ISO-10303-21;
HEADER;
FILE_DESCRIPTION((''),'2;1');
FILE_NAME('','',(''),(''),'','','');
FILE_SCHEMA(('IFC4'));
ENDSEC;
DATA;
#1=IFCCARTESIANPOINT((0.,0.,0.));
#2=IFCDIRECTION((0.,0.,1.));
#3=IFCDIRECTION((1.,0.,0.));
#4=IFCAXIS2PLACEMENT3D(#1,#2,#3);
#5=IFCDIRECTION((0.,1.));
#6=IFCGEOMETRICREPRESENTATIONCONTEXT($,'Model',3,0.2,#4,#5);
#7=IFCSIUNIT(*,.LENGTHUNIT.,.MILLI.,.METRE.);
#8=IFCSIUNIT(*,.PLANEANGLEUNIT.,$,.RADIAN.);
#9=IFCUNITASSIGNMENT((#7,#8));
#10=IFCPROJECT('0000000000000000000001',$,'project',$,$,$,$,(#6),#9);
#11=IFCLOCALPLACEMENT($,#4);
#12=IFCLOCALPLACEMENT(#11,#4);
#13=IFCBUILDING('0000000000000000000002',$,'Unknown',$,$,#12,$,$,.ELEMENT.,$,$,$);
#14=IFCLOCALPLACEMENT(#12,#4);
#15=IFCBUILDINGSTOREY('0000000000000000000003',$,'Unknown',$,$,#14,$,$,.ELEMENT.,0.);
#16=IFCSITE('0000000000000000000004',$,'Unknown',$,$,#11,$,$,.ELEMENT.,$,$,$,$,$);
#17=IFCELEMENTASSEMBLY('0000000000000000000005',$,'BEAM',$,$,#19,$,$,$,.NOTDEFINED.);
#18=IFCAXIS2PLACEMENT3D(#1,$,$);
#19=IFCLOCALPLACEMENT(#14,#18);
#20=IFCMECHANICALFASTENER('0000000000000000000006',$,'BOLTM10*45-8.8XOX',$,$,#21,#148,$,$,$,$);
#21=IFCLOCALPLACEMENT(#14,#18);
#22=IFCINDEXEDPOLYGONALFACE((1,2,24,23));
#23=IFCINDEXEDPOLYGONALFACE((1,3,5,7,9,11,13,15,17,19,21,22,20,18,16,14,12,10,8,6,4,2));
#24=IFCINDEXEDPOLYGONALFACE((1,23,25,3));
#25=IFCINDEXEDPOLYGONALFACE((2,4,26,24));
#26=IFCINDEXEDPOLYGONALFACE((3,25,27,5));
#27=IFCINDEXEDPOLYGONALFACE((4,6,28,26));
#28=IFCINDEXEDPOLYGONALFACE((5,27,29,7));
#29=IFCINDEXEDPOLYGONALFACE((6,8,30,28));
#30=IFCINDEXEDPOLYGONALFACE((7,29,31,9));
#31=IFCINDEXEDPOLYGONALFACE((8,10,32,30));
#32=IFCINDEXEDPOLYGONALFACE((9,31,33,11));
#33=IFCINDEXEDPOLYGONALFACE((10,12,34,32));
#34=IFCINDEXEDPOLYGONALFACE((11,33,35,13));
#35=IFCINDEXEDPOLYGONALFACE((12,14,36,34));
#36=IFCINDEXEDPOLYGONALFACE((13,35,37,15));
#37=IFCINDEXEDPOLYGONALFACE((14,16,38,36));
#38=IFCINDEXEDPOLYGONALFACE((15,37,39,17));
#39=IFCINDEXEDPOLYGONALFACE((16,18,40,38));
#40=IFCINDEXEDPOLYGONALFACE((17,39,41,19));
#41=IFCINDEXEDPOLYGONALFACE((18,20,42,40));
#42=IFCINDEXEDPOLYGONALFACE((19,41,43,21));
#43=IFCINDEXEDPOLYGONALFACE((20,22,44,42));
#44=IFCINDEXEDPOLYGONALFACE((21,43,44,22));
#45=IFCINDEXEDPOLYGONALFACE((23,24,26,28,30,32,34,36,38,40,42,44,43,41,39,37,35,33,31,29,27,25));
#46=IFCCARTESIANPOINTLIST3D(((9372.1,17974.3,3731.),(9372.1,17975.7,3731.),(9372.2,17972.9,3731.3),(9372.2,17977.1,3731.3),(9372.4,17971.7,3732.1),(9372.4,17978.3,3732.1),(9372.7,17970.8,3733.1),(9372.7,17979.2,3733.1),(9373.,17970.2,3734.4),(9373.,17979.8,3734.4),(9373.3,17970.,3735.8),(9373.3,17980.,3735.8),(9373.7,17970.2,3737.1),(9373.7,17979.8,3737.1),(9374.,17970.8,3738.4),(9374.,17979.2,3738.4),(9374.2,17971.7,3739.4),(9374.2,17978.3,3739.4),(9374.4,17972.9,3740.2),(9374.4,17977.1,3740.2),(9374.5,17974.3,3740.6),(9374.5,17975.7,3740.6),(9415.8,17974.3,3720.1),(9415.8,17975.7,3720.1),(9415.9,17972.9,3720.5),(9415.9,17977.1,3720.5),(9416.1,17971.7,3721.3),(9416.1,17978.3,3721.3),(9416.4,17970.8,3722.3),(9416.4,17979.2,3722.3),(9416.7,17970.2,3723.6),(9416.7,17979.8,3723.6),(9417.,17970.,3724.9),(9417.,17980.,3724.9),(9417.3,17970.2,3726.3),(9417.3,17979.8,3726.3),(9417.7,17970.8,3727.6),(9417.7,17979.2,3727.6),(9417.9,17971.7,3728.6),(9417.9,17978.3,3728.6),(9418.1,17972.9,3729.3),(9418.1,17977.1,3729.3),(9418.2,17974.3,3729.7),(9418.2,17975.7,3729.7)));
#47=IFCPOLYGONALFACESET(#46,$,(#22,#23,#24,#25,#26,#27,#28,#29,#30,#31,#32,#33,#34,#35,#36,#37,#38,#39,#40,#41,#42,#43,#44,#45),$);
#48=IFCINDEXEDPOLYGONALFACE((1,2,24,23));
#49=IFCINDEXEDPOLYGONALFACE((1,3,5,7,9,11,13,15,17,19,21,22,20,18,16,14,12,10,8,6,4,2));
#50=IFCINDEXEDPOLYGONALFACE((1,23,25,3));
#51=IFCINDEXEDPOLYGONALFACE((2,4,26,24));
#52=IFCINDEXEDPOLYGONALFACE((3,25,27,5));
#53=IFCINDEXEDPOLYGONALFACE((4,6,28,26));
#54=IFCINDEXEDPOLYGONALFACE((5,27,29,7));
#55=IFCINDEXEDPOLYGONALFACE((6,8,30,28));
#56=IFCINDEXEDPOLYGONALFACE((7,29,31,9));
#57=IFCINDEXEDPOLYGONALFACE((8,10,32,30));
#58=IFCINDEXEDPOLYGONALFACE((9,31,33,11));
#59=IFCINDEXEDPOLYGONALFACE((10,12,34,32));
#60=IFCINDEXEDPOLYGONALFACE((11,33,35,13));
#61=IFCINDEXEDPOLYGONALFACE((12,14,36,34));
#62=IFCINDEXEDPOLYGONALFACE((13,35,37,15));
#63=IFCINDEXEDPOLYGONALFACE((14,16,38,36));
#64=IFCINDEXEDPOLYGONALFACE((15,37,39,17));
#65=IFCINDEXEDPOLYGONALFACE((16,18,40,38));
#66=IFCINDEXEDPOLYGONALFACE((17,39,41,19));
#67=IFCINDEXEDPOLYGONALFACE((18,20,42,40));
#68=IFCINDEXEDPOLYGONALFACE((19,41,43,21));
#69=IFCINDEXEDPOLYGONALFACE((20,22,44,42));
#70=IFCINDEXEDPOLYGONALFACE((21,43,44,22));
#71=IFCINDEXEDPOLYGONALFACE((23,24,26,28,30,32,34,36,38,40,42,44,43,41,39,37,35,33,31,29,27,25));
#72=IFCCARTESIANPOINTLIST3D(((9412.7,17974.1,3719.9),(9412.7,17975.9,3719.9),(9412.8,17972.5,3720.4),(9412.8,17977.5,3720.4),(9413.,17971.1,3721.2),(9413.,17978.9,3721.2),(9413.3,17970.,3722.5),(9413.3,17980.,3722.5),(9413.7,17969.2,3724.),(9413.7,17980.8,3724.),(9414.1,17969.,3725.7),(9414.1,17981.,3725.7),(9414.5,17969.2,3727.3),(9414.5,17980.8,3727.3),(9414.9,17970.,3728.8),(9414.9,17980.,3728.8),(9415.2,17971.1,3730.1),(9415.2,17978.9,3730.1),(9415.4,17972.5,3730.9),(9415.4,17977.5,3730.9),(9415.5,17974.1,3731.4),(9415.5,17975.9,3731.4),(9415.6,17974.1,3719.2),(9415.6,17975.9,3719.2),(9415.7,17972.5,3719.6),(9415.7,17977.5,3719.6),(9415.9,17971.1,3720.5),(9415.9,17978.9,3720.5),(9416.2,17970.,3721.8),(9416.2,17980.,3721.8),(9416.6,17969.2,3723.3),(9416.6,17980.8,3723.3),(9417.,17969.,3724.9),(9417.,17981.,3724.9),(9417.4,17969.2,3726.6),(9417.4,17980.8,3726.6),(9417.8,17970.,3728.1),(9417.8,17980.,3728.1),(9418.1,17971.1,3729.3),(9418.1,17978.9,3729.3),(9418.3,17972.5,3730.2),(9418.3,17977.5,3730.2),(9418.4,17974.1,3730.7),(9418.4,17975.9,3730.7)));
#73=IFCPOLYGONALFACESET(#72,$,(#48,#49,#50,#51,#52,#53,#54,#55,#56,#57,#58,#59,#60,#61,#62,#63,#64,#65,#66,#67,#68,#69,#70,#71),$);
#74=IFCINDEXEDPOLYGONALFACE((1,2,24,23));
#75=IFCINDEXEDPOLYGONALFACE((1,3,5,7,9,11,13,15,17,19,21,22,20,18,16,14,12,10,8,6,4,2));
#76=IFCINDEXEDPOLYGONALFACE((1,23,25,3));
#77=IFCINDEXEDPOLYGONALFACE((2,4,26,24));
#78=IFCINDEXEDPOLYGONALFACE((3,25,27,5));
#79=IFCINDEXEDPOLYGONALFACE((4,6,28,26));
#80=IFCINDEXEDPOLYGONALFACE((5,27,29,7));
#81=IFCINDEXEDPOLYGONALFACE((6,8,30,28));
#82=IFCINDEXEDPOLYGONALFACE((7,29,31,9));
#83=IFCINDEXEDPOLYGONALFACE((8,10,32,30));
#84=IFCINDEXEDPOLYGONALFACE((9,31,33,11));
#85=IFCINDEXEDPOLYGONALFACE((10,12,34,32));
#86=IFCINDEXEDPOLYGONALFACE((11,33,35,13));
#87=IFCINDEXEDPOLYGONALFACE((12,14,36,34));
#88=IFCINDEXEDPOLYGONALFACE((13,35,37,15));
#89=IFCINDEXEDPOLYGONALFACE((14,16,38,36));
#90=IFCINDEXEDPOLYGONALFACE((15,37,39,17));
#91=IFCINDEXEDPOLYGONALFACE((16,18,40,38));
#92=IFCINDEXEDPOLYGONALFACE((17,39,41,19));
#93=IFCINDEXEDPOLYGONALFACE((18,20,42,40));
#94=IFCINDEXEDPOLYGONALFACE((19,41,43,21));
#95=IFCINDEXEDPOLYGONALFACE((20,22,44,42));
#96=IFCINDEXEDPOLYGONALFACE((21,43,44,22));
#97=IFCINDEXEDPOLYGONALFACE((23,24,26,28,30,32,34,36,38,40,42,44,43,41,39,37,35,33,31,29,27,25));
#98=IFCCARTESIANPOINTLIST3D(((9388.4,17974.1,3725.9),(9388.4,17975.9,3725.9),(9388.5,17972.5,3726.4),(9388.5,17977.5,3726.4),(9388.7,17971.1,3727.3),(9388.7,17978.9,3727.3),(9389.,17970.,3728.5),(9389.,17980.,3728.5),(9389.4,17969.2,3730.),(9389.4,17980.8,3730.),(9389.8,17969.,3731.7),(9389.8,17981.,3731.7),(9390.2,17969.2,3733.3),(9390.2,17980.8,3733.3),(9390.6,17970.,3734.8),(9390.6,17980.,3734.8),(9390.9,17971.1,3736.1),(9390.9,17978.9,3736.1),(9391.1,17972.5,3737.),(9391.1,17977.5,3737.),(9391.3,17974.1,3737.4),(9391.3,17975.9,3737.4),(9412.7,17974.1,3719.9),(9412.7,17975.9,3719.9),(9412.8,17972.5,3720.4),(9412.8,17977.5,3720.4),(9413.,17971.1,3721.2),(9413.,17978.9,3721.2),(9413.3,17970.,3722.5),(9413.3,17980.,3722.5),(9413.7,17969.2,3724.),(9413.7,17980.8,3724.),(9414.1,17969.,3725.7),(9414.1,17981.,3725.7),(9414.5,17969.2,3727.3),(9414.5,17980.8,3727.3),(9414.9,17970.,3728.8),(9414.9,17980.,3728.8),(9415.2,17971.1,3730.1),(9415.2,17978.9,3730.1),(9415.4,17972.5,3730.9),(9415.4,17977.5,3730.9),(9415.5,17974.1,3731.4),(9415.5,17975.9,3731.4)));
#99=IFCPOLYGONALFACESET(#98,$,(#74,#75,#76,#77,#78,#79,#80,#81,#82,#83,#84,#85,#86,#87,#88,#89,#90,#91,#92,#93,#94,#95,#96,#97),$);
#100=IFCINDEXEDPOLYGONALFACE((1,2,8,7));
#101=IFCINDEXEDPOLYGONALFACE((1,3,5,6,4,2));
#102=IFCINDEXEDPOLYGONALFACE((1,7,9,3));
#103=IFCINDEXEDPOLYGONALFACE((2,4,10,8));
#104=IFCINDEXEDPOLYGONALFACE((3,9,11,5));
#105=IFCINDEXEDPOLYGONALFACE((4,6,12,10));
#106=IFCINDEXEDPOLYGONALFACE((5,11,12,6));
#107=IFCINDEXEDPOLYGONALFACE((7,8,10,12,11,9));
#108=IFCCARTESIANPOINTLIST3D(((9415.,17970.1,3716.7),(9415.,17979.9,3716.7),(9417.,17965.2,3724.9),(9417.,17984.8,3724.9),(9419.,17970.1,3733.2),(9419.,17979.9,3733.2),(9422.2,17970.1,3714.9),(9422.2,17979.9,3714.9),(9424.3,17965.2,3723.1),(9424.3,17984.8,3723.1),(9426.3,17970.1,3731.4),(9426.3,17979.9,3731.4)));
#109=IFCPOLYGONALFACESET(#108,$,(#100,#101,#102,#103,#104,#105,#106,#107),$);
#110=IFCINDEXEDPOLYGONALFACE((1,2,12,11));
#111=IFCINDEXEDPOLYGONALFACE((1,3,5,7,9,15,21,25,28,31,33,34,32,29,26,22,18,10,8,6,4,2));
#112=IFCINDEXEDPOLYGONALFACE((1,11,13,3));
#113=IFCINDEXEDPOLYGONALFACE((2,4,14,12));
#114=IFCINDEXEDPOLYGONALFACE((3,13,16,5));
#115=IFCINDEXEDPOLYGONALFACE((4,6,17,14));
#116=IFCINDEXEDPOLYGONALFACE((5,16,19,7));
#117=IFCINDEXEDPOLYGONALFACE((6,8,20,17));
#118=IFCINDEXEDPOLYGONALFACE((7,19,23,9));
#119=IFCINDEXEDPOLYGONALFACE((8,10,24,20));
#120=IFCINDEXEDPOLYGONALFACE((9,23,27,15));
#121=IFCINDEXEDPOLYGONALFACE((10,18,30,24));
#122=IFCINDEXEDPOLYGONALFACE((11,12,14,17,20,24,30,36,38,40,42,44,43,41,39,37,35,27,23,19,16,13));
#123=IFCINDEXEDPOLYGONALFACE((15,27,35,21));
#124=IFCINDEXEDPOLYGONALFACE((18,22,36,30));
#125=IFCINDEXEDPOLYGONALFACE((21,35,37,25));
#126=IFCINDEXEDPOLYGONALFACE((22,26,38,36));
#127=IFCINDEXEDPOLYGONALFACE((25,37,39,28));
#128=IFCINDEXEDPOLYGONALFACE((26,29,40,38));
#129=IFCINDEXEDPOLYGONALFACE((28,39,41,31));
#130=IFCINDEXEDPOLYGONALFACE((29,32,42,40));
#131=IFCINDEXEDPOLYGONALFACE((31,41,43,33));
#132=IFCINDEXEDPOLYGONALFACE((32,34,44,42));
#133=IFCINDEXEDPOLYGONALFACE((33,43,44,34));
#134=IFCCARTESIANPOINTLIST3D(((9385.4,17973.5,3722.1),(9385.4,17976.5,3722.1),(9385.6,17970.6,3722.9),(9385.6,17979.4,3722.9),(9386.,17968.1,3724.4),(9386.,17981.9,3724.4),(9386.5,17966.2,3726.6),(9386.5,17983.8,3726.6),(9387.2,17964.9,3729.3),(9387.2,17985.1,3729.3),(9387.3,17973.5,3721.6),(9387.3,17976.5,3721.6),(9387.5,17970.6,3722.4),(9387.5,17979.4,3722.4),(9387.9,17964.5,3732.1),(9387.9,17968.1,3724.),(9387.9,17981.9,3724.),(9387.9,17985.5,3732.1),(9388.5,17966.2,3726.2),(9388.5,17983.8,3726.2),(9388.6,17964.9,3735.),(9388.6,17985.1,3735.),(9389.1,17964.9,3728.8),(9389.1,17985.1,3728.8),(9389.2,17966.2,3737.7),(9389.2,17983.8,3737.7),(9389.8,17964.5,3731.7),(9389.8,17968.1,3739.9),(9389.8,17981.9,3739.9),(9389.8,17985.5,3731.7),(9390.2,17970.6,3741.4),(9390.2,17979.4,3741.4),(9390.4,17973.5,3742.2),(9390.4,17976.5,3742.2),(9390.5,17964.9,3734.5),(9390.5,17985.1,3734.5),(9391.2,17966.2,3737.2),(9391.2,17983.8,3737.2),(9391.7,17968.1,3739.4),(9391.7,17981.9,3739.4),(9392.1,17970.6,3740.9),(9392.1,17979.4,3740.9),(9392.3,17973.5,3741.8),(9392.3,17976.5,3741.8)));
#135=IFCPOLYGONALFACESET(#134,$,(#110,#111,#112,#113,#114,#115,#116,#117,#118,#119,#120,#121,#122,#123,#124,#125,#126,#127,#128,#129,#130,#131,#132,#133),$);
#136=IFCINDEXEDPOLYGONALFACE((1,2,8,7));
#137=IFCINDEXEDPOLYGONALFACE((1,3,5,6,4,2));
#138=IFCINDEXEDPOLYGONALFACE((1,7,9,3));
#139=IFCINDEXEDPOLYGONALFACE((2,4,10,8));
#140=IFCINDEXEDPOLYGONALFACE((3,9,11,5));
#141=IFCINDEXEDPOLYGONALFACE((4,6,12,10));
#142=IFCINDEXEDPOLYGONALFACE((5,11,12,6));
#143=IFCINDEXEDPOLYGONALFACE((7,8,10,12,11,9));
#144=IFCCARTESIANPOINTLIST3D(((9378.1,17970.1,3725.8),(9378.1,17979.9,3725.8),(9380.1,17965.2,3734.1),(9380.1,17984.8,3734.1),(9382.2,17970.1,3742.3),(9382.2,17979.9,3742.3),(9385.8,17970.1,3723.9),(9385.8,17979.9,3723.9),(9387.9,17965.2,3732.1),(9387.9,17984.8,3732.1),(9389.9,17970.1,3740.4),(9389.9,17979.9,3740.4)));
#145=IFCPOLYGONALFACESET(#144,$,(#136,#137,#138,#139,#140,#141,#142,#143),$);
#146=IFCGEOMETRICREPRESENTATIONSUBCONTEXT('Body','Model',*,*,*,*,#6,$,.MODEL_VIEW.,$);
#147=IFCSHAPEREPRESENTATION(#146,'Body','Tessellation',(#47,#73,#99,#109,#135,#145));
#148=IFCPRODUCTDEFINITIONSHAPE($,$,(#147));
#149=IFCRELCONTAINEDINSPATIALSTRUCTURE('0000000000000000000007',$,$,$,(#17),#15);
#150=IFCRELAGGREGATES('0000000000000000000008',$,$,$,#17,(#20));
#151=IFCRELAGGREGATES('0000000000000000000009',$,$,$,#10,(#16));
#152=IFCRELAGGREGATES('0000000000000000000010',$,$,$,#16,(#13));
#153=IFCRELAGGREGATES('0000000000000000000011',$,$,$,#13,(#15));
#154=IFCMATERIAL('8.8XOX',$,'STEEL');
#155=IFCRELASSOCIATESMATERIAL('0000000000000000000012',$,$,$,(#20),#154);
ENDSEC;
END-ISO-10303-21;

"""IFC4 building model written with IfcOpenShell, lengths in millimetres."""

from ifc_helpers import new_model, si_unit, direction, frame, origin_with_axes, place, context, subcontext, project, spatial, line, arc, indexed_curve, outline, extrude, source, transform, mapped, material, element, aggregate, save


model = new_model("IFC4")

# Units and contexts
model_context = context("Model", 3, precision=0.2, world=origin_with_axes(), true_north=direction((0.0, 1.0)))
body_context = subcontext(model_context, "Body", "Model", "MODEL_VIEW")
ifc_project = project(units=[si_unit("LENGTHUNIT", "METRE", prefix="MILLI"), si_unit("PLANEANGLEUNIT", "RADIAN")], contexts=[model_context])

# Site, building, storey
site_placement = place(None, origin_with_axes())
site = spatial("IfcSite", under=ifc_project, at=site_placement, Name="Unknown", CompositionType="ELEMENT")
building_placement = place(site_placement, origin_with_axes())
building = spatial("IfcBuilding", under=site, at=building_placement, Name="Unknown", CompositionType="ELEMENT")
storey_placement = place(building_placement, origin_with_axes())
storey = spatial("IfcBuildingStorey", under=building, at=storey_placement, Name="Unknown", CompositionType="ELEMENT", Elevation=0.0)

# Shared definitions
ifc_material_1 = material(Name="8.8XOX", Category="STEEL")

# Element assembly, mechanical fastener
shared_shape_1 = source(origin_with_axes(), body_context, "Body", "SweptSolid", [
    extrude(outline(indexed_curve([(5.0, 0.0), (0.0, 5.0), (-5.0, 0.0), (0.0, -5.0)], segments=[arc(1, 2, 3), arc(3, 4, 1)])), frame((0.0, 0.0, 3.8), z_axis=(0.0, 0.0, -1.0), x_axis=(0.0, 1.0, 0.0)), (0.0, 0.0, 1.0), 45.0),
    extrude(outline(indexed_curve([(6.0, 0.0), (0.0, 6.0), (-6.0, 0.0), (0.0, -6.0)], segments=[arc(1, 2, 3), arc(3, 4, 1)])), frame((0.0, 0.0, 3.8), z_axis=(0.0, 0.0, -1.0), x_axis=(0.0, 1.0, 0.0)), (0.0, 0.0, 1.0), 3.0),
    extrude(outline(indexed_curve([(6.0, 0.0), (0.0, 6.0), (-6.0, 0.0), (0.0, -6.0)], segments=[arc(1, 2, 3), arc(3, 4, 1)])), frame((0.0, 0.0, 0.8), z_axis=(0.0, 0.0, -1.0), x_axis=(0.0, 1.0, 0.0)), (0.0, 0.0, 1.0), 25.0),
    extrude(outline(indexed_curve([(9.8, 0.0), (4.9, 8.5), (-4.9, 8.5), (-9.8, 0.0), (-4.9, -8.5), (4.9, -8.5)], segments=[line(1, 2, 3, 4, 5, 6, 1)])), frame((0.0, 0.0, 11.2), z_axis=(0.0, 0.0, -1.0), x_axis=(0.0, 1.0, 0.0)), (0.0, 0.0, 1.0), 7.5),
    extrude(outline(indexed_curve([(10.5, 0.0), (0.0, 10.5), (-10.5, 0.0), (0.0, -10.5)], segments=[arc(1, 2, 3), arc(3, 4, 1)])), frame((0.0, 0.0, -24.2), z_axis=(0.0, 0.0, -1.0), x_axis=(0.0, 1.0, 0.0)), (0.0, 0.0, 1.0), 2.0),
    extrude(outline(indexed_curve([(9.8, 0.0), (4.9, 8.5), (-4.9, 8.5), (-9.8, 0.0), (-4.9, -8.5), (4.9, -8.5)], segments=[line(1, 2, 3, 4, 5, 6, 1)])), frame((0.0, 0.0, -26.2), z_axis=(0.0, 0.0, -1.0), x_axis=(0.0, 1.0, 0.0)), (0.0, 0.0, 1.0), 8.0),
])
assembly_1_placement = place(storey_placement, frame((9403.2, 12000.0, 3733.5), z_axis=(0.970613, 0.0, -0.240648), x_axis=(0.0, 1.0, 0.0)))
assembly_1 = element("IfcElementAssembly", 1, at=assembly_1_placement, inside=storey, Name="BEAM", PredefinedType="NOTDEFINED")
mechanical_fastener_1_placement = place(assembly_1_placement, frame((5975.0, -5.0, 11.8), z_axis=(0.0, 0.0, 1.0), x_axis=(0.0, 1.0, 0.0)))
mechanical_fastener_1 = element("IfcMechanicalFastener", 2, at=mechanical_fastener_1_placement, material=ifc_material_1, Name="BOLTM10*45-8.8XOX", context=body_context, shape_type="MappedRepresentation", body=[
    mapped(shared_shape_1, transform((0.0, 0.0, 0.0))),
])
aggregate(assembly_1, [mechanical_fastener_1])

save(model, "model.ifc")
